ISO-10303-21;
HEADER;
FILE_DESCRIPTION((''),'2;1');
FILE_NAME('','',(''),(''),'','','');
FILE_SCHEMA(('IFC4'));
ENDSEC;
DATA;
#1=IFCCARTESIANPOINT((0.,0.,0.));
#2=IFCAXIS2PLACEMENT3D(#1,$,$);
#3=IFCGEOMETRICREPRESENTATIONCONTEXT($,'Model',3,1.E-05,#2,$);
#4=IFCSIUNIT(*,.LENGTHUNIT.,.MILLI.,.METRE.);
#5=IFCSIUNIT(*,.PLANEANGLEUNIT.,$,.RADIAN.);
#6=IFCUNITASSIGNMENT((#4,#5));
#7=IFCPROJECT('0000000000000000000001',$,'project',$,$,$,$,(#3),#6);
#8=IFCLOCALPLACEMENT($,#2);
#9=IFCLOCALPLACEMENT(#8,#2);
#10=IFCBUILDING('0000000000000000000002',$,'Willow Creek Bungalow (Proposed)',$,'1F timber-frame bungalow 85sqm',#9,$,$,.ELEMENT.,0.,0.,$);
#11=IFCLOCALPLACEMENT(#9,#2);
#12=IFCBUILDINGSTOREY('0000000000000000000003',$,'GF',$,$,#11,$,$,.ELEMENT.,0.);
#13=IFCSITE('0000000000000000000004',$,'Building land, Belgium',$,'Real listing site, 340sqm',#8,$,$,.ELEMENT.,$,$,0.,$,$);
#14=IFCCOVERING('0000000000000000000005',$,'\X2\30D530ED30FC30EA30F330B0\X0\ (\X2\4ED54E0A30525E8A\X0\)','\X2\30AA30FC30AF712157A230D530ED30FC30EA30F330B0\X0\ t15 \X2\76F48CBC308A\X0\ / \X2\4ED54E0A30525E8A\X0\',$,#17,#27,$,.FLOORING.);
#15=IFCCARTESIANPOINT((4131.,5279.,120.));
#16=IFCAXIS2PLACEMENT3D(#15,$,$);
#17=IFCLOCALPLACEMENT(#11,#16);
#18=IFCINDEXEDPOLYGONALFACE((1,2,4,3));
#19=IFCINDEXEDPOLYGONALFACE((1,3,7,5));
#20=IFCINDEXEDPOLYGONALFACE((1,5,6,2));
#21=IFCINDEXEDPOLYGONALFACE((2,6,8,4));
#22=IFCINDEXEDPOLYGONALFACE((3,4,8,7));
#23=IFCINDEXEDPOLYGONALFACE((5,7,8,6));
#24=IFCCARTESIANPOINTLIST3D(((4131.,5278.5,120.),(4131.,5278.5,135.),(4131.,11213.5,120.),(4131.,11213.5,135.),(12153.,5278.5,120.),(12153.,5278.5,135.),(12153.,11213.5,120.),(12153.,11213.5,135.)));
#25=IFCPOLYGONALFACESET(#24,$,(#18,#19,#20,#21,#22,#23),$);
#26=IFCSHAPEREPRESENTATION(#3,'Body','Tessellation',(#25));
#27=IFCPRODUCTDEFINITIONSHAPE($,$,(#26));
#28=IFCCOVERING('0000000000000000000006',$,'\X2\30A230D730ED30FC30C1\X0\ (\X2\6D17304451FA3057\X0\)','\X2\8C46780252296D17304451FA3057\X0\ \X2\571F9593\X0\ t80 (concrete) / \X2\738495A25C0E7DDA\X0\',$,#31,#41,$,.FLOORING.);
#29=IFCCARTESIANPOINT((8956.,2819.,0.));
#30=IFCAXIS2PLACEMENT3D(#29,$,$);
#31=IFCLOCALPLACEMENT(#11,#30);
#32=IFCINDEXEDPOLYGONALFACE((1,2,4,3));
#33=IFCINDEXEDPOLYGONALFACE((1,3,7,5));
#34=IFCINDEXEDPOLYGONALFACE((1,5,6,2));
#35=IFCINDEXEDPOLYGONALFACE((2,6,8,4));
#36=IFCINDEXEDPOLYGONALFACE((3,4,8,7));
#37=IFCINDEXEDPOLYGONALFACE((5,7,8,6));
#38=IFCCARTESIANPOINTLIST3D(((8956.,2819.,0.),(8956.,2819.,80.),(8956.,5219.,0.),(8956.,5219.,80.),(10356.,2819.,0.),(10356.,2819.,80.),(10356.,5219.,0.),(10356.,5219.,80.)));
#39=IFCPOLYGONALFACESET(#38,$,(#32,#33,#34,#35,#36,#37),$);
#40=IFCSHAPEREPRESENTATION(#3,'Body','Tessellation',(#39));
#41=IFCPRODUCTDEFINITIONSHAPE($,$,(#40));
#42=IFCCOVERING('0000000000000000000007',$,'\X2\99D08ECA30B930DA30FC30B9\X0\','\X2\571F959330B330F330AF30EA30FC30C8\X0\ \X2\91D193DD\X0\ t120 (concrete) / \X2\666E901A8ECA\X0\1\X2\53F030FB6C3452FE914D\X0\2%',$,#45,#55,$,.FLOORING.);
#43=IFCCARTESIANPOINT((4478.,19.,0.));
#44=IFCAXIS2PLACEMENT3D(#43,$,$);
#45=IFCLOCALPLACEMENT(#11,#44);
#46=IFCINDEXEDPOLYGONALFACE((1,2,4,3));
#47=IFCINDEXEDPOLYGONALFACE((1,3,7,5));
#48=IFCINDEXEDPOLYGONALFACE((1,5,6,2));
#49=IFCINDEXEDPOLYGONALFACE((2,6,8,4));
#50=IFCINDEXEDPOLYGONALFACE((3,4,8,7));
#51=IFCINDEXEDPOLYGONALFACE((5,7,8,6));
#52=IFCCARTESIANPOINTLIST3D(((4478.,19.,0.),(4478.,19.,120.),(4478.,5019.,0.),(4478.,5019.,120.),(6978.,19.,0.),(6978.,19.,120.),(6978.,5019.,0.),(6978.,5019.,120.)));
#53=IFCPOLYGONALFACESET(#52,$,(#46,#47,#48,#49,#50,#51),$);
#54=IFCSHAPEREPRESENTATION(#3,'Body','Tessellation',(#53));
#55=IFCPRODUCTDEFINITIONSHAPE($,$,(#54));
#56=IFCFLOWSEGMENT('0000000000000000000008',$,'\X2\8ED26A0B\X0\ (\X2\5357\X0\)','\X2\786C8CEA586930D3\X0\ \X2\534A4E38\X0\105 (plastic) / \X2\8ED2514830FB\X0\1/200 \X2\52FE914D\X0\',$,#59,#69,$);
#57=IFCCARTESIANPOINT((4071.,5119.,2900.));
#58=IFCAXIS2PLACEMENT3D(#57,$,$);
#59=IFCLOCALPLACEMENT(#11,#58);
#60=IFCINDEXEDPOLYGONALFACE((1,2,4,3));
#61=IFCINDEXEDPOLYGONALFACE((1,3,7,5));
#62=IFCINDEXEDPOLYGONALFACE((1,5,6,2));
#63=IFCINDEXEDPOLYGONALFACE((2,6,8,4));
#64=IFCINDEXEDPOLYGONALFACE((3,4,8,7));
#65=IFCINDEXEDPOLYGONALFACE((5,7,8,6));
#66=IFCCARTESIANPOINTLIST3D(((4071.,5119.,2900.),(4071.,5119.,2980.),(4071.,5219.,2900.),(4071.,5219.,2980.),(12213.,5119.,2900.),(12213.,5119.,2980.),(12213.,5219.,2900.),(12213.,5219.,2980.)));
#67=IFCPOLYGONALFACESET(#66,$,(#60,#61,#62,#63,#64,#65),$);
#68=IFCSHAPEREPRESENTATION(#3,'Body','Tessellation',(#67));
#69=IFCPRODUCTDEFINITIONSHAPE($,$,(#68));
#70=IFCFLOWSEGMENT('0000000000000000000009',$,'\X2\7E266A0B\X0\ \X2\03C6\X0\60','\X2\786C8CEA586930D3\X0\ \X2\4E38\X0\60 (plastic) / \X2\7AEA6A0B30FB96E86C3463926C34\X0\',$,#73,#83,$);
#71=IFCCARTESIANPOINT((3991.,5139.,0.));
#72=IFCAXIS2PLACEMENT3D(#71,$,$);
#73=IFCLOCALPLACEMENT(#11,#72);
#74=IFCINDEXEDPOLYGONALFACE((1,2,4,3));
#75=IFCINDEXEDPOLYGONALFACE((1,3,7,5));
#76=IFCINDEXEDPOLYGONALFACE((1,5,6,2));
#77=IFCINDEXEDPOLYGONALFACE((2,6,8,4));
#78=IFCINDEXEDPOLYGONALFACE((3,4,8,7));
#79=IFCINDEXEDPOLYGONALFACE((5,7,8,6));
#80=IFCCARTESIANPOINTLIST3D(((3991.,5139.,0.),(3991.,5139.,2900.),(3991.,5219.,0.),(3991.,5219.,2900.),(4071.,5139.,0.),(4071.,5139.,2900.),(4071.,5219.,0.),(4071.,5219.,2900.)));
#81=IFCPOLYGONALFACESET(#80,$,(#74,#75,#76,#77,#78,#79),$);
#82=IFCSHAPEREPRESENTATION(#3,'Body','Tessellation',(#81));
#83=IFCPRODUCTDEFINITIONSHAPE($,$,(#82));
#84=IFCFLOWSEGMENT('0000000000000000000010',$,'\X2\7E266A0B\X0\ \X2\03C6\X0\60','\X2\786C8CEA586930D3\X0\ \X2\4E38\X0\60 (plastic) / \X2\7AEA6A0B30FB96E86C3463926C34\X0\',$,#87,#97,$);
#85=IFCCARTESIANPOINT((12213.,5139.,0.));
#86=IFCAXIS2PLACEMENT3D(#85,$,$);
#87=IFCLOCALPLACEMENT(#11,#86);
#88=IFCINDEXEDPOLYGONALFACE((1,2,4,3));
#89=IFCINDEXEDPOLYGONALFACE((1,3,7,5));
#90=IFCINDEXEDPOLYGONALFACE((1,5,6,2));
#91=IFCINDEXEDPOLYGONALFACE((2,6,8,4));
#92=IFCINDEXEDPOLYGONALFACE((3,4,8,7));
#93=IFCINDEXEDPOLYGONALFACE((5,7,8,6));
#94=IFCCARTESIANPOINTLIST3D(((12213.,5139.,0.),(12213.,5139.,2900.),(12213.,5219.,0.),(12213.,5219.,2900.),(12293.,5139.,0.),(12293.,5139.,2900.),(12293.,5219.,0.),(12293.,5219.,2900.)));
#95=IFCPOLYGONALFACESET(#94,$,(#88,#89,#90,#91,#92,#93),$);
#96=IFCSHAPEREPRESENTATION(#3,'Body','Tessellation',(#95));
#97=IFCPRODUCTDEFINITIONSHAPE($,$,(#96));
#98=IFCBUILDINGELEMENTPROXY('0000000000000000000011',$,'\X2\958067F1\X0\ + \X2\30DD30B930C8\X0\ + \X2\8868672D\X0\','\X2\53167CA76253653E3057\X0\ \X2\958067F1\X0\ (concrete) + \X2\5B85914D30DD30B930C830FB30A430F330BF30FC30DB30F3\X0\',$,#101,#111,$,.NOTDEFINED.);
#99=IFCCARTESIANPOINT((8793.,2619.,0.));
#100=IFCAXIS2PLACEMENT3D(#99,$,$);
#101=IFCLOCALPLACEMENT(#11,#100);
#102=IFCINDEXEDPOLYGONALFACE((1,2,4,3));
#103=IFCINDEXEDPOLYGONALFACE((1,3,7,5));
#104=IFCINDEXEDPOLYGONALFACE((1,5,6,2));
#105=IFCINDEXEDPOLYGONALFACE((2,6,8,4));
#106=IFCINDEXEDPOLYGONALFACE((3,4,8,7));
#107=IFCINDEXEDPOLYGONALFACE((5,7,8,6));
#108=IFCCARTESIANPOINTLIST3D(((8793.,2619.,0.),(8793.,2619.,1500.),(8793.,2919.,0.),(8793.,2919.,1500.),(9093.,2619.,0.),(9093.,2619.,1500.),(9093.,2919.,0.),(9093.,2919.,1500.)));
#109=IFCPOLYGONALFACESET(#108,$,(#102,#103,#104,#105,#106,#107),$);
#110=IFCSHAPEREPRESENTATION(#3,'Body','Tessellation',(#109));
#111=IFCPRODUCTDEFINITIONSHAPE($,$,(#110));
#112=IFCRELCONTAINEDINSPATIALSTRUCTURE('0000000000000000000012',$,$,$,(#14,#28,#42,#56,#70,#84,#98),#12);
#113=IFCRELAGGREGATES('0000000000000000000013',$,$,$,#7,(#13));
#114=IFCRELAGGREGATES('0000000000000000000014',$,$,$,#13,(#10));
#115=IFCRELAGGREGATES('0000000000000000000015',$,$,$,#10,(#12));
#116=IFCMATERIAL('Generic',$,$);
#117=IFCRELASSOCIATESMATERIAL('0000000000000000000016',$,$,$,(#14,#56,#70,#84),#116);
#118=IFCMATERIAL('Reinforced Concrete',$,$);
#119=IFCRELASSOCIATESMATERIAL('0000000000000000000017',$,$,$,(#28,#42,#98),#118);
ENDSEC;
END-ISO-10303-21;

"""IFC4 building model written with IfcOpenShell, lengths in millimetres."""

from ifc_helpers import new_model, si_unit, frame, frame_2d, origin, place, context, project, spatial, rectangle, extrude, material, element, save


model = new_model("IFC4")

# Units and contexts
model_context = context("Model", 3, precision=1e-05, world=origin())
ifc_project = project(units=[si_unit("LENGTHUNIT", "METRE", prefix="MILLI"), si_unit("PLANEANGLEUNIT", "RADIAN")], contexts=[model_context])

# Site, building, storey
site_placement = place(None, origin())
site = spatial("IfcSite", under=ifc_project, at=site_placement, Name="Building land, Belgium", ObjectType="Real listing site, 340sqm", CompositionType="ELEMENT", RefElevation=0.0)
building_placement = place(site_placement, origin())
building = spatial("IfcBuilding", under=site, at=building_placement, Name="Willow Creek Bungalow (Proposed)", ObjectType="1F timber-frame bungalow 85sqm", CompositionType="ELEMENT", ElevationOfRefHeight=0.0, ElevationOfTerrain=0.0)
storey_placement = place(building_placement, origin())
storey = spatial("IfcBuildingStorey", under=building, at=storey_placement, Name="GF", CompositionType="ELEMENT", Elevation=0.0)

# Shared definitions
ifc_material_1 = material(Name="Reinforced Concrete")

# Coverings
ifc_material_2 = material(Name="Generic")
covering_1_placement = place(storey_placement, frame((4131.0, 5279.0, 120.0)))
element("IfcCovering", 1, at=covering_1_placement, inside=storey, material=ifc_material_2, Name="フローリング (仕上げ床)", Description="オーク無垢フローリング t15 直貼り / 仕上げ床", PredefinedType="FLOORING", context=model_context, shape_type="SweptSolid", body=[
    extrude(rectangle(XDim=8022.0, YDim=5935.0, at=frame_2d((4011.0, 2967.0))), frame((4131.0, 5279.0, 120.0)), (0.0, 0.0, 1.0), 15.0),
])
covering_2_placement = place(storey_placement, frame((8956.0, 2819.0, 0.0)))
element("IfcCovering", 2, at=covering_2_placement, inside=storey, material=ifc_material_1, Name="アプローチ (洗い出し)", Description="豆砂利洗い出し 土間 t80 (concrete) / 玄関導線", PredefinedType="FLOORING", context=model_context, shape_type="SweptSolid", body=[
    extrude(rectangle(XDim=1400.0, YDim=2400.0, at=frame_2d((700.0, 1200.0))), frame((8956.0, 2819.0, 0.0)), (0.0, 0.0, 1.0), 80.0),
])
covering_3_placement = place(storey_placement, frame((4478.0, 19.0, 0.0)))
element("IfcCovering", 3, at=covering_3_placement, inside=storey, material=ifc_material_1, Name="駐車スペース", Description="土間コンクリート 金鏝 t120 (concrete) / 普通車1台・水勾配2%", PredefinedType="FLOORING", context=model_context, shape_type="SweptSolid", body=[
    extrude(rectangle(XDim=2500.0, YDim=5000.0, at=frame_2d((1250.0, 2500.0))), frame((4478.0, 19.0, 0.0)), (0.0, 0.0, 1.0), 120.0),
])

# Flow segments
flow_segment_1_placement = place(storey_placement, frame((4071.0, 5119.0, 2900.0)))
element("IfcFlowSegment", 4, at=flow_segment_1_placement, inside=storey, material=ifc_material_2, Name="軒樋 (南)", Description="硬質塩ビ 半丸105 (plastic) / 軒先・1/200 勾配", context=model_context, shape_type="SweptSolid", body=[
    extrude(rectangle(XDim=8142.0, YDim=100.0, at=frame_2d((4071.0, 50.0))), frame((4071.0, 5119.0, 2900.0)), (0.0, 0.0, 1.0), 80.0),
])
flow_segment_2_placement = place(storey_placement, frame((3991.0, 5139.0, 0.0)))
element("IfcFlowSegment", 5, at=flow_segment_2_placement, inside=storey, material=ifc_material_2, Name="縦樋 φ60", Description="硬質塩ビ 丸60 (plastic) / 竪樋・雨水排水", context=model_context, shape_type="SweptSolid", body=[
    extrude(rectangle(XDim=80.0, YDim=80.0, at=frame_2d((40.0, 40.0))), frame((3991.0, 5139.0, 0.0)), (0.0, 0.0, 1.0), 2900.0),
])
flow_segment_3_placement = place(storey_placement, frame((12213.0, 5139.0, 0.0)))
element("IfcFlowSegment", 6, at=flow_segment_3_placement, inside=storey, material=ifc_material_2, Name="縦樋 φ60", Description="硬質塩ビ 丸60 (plastic) / 竪樋・雨水排水", context=model_context, shape_type="SweptSolid", body=[
    extrude(rectangle(XDim=80.0, YDim=80.0, at=frame_2d((40.0, 40.0))), frame((12213.0, 5139.0, 0.0)), (0.0, 0.0, 1.0), 2900.0),
])

# Building element proxy
proxy_placement = place(storey_placement, frame((8793.0, 2619.0, 0.0)))
element("IfcBuildingElementProxy", 7, at=proxy_placement, inside=storey, material=ifc_material_1, Name="門柱 + ポスト + 表札", Description="化粧打放し 門柱 (concrete) + 宅配ポスト・インターホン", PredefinedType="NOTDEFINED", context=model_context, shape_type="SweptSolid", body=[
    extrude(rectangle(XDim=300.0, YDim=300.0, at=frame_2d((150.0, 150.0))), frame((8793.0, 2619.0, 0.0)), (0.0, 0.0, 1.0), 1500.0),
])

save(model, "model.ifc")
